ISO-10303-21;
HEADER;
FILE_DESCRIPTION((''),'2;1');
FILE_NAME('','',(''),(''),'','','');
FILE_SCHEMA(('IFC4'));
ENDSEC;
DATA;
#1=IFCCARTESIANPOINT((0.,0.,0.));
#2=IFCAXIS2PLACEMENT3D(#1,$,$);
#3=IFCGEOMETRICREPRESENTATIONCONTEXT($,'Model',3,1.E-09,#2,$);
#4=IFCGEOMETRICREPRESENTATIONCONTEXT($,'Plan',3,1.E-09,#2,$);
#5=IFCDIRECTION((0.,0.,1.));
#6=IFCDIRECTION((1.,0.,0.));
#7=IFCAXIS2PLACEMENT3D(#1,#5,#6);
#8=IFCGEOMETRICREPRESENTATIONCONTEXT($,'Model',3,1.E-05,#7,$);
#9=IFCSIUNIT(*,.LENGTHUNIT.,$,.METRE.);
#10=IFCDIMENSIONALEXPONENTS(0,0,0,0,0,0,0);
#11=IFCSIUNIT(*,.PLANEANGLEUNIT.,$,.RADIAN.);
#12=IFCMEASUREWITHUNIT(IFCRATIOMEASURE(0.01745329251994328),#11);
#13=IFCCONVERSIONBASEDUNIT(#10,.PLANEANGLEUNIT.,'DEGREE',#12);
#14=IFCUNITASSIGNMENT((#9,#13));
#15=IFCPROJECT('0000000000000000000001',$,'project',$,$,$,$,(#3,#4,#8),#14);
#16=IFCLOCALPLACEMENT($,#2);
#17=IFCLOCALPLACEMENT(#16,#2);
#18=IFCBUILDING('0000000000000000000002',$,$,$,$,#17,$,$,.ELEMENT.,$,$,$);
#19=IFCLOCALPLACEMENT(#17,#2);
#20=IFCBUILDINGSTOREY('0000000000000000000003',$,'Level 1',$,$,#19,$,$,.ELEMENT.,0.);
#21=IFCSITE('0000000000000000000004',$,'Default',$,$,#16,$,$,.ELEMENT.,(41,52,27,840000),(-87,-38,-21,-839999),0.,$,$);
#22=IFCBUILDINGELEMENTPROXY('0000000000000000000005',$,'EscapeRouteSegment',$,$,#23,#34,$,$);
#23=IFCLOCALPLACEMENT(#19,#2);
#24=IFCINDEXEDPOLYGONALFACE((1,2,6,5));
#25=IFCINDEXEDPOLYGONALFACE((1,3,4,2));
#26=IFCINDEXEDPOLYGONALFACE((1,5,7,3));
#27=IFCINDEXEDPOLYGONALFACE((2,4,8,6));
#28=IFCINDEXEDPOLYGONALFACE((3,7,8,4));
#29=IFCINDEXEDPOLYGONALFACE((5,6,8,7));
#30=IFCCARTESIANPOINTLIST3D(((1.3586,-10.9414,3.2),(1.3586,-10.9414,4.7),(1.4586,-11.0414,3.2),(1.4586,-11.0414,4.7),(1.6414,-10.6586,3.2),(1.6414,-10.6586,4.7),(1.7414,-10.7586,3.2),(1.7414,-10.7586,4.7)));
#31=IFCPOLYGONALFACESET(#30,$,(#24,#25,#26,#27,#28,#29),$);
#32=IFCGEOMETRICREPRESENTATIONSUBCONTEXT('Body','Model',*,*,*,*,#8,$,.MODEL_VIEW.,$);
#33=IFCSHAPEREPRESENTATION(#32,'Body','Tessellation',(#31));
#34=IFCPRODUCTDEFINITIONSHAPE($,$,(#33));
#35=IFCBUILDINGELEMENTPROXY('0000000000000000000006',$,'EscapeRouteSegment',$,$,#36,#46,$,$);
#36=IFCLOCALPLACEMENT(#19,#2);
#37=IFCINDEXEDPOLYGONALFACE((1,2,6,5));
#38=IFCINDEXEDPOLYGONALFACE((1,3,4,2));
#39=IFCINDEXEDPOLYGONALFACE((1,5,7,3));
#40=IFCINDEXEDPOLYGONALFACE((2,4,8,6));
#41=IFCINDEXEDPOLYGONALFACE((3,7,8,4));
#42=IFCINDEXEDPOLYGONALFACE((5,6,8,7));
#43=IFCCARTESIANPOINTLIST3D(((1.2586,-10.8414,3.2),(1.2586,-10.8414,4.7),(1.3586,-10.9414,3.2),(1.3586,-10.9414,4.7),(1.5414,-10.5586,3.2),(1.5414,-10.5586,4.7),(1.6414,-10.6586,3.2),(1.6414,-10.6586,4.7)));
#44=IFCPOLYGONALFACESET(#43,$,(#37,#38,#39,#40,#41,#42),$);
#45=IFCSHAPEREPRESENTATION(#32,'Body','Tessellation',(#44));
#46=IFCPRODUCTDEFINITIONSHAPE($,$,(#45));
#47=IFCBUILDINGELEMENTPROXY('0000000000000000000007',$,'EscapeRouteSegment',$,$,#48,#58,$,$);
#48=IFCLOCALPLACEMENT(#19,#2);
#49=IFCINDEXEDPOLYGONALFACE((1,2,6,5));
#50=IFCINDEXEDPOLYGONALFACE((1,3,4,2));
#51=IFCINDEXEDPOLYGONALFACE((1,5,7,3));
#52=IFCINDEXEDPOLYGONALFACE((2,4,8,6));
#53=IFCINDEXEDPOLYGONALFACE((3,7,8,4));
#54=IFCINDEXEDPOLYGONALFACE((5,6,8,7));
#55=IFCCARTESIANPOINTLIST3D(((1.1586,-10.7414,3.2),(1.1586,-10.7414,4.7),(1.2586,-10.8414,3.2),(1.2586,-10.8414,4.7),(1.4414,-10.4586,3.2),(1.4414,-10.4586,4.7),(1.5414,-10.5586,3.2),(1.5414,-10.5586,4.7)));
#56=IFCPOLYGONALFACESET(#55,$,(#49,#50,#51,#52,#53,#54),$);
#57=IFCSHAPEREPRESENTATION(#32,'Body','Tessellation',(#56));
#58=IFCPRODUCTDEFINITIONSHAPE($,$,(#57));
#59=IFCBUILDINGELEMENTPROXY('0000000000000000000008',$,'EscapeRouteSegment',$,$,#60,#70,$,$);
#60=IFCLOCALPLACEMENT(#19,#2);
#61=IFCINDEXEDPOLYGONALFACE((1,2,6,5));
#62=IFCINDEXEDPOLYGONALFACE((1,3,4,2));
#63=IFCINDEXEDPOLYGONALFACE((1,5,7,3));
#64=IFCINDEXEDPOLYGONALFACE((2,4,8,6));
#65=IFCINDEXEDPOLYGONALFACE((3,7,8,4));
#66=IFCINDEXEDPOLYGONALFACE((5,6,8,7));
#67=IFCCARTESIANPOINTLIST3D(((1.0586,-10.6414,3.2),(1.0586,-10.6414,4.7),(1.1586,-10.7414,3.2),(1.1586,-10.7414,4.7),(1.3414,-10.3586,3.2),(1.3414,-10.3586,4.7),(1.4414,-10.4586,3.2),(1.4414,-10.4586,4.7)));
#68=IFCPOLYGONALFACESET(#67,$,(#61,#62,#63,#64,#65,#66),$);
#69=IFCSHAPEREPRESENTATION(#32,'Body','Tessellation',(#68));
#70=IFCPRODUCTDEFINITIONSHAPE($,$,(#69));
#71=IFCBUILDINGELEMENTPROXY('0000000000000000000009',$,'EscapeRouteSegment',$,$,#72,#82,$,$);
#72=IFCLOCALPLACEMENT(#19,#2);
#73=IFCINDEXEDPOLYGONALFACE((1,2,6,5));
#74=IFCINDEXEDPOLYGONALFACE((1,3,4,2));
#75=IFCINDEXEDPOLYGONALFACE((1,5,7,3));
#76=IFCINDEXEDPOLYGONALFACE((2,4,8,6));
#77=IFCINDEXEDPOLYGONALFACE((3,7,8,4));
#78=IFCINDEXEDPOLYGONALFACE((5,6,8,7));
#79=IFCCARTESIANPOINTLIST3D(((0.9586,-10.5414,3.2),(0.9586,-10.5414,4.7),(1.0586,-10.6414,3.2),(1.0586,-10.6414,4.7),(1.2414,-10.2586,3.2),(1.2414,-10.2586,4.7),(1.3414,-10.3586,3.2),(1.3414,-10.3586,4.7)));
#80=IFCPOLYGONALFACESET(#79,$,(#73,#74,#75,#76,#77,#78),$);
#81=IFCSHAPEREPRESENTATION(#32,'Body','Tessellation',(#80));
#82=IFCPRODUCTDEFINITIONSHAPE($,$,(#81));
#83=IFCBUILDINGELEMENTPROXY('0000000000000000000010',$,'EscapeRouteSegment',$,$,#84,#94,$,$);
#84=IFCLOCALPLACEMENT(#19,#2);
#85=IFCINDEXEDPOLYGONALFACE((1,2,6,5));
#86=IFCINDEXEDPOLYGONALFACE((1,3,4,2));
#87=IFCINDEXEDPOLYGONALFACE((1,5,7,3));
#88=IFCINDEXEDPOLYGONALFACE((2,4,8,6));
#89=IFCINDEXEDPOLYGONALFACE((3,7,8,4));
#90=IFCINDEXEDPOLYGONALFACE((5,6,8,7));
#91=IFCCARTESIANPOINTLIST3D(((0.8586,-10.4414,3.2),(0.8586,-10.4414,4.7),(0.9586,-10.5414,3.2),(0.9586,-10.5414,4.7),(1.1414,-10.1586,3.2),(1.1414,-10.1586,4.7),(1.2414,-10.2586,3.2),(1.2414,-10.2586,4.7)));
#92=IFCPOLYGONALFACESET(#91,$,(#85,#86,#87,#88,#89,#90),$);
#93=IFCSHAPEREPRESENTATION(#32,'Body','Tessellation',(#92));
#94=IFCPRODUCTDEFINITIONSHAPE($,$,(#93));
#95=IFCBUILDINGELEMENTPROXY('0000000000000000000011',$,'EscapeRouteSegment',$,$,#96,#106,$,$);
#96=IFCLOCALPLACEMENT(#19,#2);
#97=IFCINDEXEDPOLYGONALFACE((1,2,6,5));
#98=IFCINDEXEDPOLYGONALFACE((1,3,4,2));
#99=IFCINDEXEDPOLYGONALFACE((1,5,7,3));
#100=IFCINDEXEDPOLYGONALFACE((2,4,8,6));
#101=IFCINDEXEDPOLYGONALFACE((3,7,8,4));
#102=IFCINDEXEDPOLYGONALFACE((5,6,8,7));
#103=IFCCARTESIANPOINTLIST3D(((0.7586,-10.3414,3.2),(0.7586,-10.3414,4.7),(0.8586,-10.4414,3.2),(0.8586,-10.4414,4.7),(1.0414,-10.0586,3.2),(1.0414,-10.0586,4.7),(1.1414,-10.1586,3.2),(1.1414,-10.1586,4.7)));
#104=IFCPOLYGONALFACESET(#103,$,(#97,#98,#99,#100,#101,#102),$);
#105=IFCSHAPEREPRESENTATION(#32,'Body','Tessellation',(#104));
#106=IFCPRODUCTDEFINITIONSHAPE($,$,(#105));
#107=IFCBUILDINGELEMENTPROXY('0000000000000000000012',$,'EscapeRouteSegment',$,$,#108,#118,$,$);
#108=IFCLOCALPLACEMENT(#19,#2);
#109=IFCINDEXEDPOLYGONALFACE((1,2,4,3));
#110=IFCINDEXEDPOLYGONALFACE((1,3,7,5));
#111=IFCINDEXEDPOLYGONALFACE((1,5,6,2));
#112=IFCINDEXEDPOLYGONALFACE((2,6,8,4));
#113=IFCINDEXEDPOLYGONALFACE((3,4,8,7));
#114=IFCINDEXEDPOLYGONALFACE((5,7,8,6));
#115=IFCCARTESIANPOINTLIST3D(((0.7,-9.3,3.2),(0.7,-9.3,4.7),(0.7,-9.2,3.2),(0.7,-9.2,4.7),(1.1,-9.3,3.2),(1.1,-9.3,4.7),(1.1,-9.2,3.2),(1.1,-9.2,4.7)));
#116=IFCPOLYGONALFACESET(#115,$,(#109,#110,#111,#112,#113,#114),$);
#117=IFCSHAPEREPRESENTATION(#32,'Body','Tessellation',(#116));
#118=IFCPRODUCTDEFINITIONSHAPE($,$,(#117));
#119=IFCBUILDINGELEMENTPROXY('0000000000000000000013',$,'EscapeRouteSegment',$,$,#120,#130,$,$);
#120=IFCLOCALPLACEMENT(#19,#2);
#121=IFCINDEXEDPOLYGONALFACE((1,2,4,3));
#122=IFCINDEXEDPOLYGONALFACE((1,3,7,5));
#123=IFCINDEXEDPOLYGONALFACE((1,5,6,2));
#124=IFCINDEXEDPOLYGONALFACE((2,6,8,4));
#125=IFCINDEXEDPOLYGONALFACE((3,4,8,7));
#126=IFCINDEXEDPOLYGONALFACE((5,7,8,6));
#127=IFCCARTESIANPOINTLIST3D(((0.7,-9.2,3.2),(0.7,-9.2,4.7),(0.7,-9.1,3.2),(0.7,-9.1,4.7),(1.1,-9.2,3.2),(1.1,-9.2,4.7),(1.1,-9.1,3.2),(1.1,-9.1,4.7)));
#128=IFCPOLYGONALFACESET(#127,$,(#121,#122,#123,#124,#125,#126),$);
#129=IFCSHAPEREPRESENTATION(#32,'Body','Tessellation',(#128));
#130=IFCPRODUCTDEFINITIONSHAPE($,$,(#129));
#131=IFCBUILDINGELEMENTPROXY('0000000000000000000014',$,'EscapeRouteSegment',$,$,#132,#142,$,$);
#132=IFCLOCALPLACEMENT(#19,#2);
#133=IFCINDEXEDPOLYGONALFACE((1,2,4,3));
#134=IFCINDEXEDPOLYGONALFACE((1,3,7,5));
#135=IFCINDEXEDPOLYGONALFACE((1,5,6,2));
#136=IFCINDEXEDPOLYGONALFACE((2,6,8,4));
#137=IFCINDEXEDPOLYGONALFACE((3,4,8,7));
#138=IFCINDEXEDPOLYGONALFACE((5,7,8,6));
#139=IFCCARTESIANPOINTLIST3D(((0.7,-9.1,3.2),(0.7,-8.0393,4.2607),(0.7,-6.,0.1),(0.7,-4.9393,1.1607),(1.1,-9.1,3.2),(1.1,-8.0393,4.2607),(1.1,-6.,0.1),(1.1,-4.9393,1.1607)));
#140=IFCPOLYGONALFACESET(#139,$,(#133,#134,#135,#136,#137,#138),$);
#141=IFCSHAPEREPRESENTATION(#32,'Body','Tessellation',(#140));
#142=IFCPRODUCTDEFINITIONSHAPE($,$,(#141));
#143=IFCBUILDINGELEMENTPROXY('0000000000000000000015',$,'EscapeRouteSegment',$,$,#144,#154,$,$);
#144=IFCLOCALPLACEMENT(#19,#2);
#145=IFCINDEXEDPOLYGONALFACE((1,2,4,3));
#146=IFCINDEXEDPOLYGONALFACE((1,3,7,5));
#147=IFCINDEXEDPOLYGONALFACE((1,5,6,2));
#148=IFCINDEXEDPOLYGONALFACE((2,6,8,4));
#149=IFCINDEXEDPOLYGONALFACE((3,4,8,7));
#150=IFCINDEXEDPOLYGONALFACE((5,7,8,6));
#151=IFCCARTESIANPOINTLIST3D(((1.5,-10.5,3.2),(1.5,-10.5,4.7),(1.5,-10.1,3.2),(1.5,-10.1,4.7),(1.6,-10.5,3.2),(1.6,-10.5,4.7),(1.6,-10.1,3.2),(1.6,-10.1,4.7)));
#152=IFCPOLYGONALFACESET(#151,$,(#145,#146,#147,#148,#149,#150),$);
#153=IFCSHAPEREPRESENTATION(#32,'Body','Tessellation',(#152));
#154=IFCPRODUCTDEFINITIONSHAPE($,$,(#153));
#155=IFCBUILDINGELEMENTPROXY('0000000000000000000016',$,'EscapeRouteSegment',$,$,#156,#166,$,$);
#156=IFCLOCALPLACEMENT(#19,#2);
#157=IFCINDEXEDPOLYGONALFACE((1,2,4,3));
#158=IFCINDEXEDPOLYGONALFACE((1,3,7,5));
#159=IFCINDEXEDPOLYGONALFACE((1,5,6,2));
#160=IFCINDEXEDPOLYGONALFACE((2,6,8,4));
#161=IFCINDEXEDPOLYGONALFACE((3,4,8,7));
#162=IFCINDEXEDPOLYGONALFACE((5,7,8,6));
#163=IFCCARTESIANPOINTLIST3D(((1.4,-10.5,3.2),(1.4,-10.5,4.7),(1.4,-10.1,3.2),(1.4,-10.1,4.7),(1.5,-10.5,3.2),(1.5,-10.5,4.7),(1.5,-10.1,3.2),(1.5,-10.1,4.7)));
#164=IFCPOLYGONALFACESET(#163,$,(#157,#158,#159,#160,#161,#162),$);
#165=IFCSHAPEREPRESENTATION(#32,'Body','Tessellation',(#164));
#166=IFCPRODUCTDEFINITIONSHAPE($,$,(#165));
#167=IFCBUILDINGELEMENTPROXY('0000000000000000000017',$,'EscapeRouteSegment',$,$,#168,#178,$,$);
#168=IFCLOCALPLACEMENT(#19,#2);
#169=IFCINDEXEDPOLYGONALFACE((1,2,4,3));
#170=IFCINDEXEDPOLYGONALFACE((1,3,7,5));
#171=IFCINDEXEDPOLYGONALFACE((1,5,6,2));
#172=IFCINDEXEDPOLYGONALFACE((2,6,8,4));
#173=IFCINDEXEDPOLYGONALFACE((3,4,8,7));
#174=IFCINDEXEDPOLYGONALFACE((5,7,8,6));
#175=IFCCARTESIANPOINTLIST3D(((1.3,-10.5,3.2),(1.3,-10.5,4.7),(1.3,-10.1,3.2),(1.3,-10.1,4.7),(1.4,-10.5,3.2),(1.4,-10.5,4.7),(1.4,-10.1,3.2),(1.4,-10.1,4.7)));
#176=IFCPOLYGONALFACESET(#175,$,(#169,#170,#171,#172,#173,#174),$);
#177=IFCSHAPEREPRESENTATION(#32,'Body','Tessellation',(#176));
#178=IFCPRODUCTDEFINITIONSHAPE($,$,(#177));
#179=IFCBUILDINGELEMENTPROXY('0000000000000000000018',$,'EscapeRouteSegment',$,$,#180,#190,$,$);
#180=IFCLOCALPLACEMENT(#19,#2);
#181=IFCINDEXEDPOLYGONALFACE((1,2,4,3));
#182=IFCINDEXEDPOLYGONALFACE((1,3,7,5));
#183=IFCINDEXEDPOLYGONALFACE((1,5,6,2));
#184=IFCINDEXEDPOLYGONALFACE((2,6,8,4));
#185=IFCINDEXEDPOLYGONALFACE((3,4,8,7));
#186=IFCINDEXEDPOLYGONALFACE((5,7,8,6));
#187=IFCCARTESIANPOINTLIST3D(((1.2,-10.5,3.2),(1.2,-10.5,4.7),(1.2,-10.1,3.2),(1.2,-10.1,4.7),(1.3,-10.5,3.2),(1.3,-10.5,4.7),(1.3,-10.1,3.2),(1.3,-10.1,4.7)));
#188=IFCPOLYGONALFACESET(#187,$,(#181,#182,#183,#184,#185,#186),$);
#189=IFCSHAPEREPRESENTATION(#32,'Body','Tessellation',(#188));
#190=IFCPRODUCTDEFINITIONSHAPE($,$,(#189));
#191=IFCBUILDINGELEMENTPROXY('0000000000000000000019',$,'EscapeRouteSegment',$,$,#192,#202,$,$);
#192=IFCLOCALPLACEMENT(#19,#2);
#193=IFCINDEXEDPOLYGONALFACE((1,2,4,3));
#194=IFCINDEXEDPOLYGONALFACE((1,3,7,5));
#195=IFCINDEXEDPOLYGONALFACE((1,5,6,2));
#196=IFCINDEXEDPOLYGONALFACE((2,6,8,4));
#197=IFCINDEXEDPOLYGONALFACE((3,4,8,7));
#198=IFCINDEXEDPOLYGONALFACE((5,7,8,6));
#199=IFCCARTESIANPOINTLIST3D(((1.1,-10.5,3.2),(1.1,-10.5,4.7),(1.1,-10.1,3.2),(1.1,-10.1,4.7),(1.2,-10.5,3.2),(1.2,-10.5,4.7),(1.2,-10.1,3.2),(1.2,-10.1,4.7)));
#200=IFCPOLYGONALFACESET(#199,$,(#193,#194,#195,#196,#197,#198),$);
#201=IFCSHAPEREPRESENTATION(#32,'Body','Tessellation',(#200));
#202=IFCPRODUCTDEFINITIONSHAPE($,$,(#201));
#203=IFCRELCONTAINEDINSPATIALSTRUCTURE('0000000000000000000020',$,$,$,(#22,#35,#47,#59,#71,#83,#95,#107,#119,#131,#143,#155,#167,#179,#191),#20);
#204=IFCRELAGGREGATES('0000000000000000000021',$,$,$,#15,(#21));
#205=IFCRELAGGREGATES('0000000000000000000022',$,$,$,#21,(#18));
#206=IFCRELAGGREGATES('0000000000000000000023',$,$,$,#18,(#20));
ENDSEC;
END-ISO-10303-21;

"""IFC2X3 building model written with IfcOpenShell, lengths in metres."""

from ifc_helpers import new_model, entity, si_unit, converted_unit, frame, origin, origin_with_axes, place, context, subcontext, project, spatial, polyline, outline, extrude, element, save


model = new_model("IFC2X3")

# Units and contexts
model_context_1 = context("Model", 3, precision=1e-09, world=origin())
plan_context = context("Plan", 3, precision=1e-09, world=origin())
model_context_2 = context("Model", 3, precision=1e-05, world=origin_with_axes())
body_context = subcontext(model_context_2, "Body", "Model", "MODEL_VIEW")
ifc_project = project(units=[si_unit("LENGTHUNIT", "METRE"), converted_unit("PLANEANGLEUNIT", "DEGREE", entity("IfcRatioMeasure", 0.01745329251994328), si_unit("PLANEANGLEUNIT", "RADIAN"), dimensions=[0, 0, 0, 0, 0, 0, 0])], contexts=[model_context_1, plan_context, model_context_2])

# Site, building, storey
site_placement = place(None, origin())
site = spatial("IfcSite", under=ifc_project, at=site_placement, Name="Default", CompositionType="ELEMENT", RefLatitude=(41, 52, 27, 840000), RefLongitude=(-87, -38, -21, -839999), RefElevation=0.0)
building_placement = place(site_placement, origin())
building = spatial("IfcBuilding", under=site, at=building_placement, CompositionType="ELEMENT")
storey_placement = place(building_placement, origin())
storey = spatial("IfcBuildingStorey", under=building, at=storey_placement, Name="Level 1", CompositionType="ELEMENT", Elevation=0.0)

# Building element proxies
proxy_1_placement = place(storey_placement, frame((1.6, -10.9, 3.2), z_axis=(0.0, 0.0, 1.0), x_axis=(-0.707109, 0.707105, 0.0)))
element("IfcBuildingElementProxy", 1, at=proxy_1_placement, inside=storey, Name="EscapeRouteSegment", context=body_context, shape_type="SweptSolid", body=[
    extrude(outline(polyline([(0.0, -0.2), (0.0, 0.2), (0.1414, 0.2), (0.1414, -0.2), (0.0, -0.2)])), origin_with_axes(), (0.0, 0.0, 1.0), 1.5),
])
proxy_2_placement = place(storey_placement, frame((1.5, -10.8, 3.2), z_axis=(0.0, 0.0, 1.0), x_axis=(-0.707105, 0.707108, 0.0)))
element("IfcBuildingElementProxy", 2, at=proxy_2_placement, inside=storey, Name="EscapeRouteSegment", context=body_context, shape_type="SweptSolid", body=[
    extrude(outline(polyline([(0.0, -0.2), (0.0, 0.2), (0.1414, 0.2), (0.1414, -0.2), (0.0, -0.2)])), origin_with_axes(), (0.0, 0.0, 1.0), 1.5),
])
proxy_3_placement = place(storey_placement, frame((1.4, -10.7, 3.2), z_axis=(0.0, 0.0, 1.0), x_axis=(-0.707109, 0.707105, 0.0)))
element("IfcBuildingElementProxy", 3, at=proxy_3_placement, inside=storey, Name="EscapeRouteSegment", context=body_context, shape_type="SweptSolid", body=[
    extrude(outline(polyline([(0.0, -0.2), (0.0, 0.2), (0.1414, 0.2), (0.1414, -0.2), (0.0, -0.2)])), origin_with_axes(), (0.0, 0.0, 1.0), 1.5),
])
proxy_4_placement = place(storey_placement, frame((1.3, -10.6, 3.2), z_axis=(0.0, 0.0, 1.0), x_axis=(-0.707105, 0.707108, 0.0)))
element("IfcBuildingElementProxy", 4, at=proxy_4_placement, inside=storey, Name="EscapeRouteSegment", context=body_context, shape_type="SweptSolid", body=[
    extrude(outline(polyline([(0.0, -0.2), (0.0, 0.2), (0.1414, 0.2), (0.1414, -0.2), (0.0, -0.2)])), origin_with_axes(), (0.0, 0.0, 1.0), 1.5),
])
proxy_5_placement = place(storey_placement, frame((1.2, -10.5, 3.2), z_axis=(0.0, 0.0, 1.0), x_axis=(-0.707105, 0.707108, 0.0)))
element("IfcBuildingElementProxy", 5, at=proxy_5_placement, inside=storey, Name="EscapeRouteSegment", context=body_context, shape_type="SweptSolid", body=[
    extrude(outline(polyline([(0.0, -0.2), (0.0, 0.2), (0.1414, 0.2), (0.1414, -0.2), (0.0, -0.2)])), origin_with_axes(), (0.0, 0.0, 1.0), 1.5),
])
proxy_6_placement = place(storey_placement, frame((1.1, -10.4, 3.2), z_axis=(0.0, 0.0, 1.0), x_axis=(-0.707109, 0.707105, 0.0)))
element("IfcBuildingElementProxy", 6, at=proxy_6_placement, inside=storey, Name="EscapeRouteSegment", context=body_context, shape_type="SweptSolid", body=[
    extrude(outline(polyline([(0.0, -0.2), (0.0, 0.2), (0.1414, 0.2), (0.1414, -0.2), (0.0, -0.2)])), origin_with_axes(), (0.0, 0.0, 1.0), 1.5),
])
proxy_7_placement = place(storey_placement, frame((1.0, -10.3, 3.2), z_axis=(0.0, 0.0, 1.0), x_axis=(-0.707105, 0.707108, 0.0)))
element("IfcBuildingElementProxy", 7, at=proxy_7_placement, inside=storey, Name="EscapeRouteSegment", context=body_context, shape_type="SweptSolid", body=[
    extrude(outline(polyline([(0.0, -0.2), (0.0, 0.2), (0.1414, 0.2), (0.1414, -0.2), (0.0, -0.2)])), origin_with_axes(), (0.0, 0.0, 1.0), 1.5),
])
proxy_8_placement = place(storey_placement, frame((0.9, -9.3, 3.2), z_axis=(0.0, 0.0, 1.0), x_axis=(0.0, 1.0, 0.0)))
element("IfcBuildingElementProxy", 8, at=proxy_8_placement, inside=storey, Name="EscapeRouteSegment", context=body_context, shape_type="SweptSolid", body=[
    extrude(outline(polyline([(0.0, -0.2), (0.0, 0.2), (0.1, 0.2), (0.1, -0.2), (0.0, -0.2)])), origin_with_axes(), (0.0, 0.0, 1.0), 1.5),
])
proxy_9_placement = place(storey_placement, frame((0.9, -9.2, 3.2), z_axis=(0.0, 0.0, 1.0), x_axis=(0.0, 1.0, 0.0)))
element("IfcBuildingElementProxy", 9, at=proxy_9_placement, inside=storey, Name="EscapeRouteSegment", context=body_context, shape_type="SweptSolid", body=[
    extrude(outline(polyline([(0.0, -0.2), (0.0, 0.2), (0.1, 0.2), (0.1, -0.2), (0.0, -0.2)])), origin_with_axes(), (0.0, 0.0, 1.0), 1.5),
])
proxy_10_placement = place(storey_placement, frame((0.9, -9.1, 3.2), z_axis=(0.0, 0.707107, 0.707107), x_axis=(0.0, 0.707107, -0.707107)))
element("IfcBuildingElementProxy", 10, at=proxy_10_placement, inside=storey, Name="EscapeRouteSegment", context=body_context, shape_type="SweptSolid", body=[
    extrude(outline(polyline([(0.0, -0.2), (0.0, 0.2), (4.3841, 0.2), (4.3841, -0.2), (0.0, -0.2)])), origin_with_axes(), (0.0, 0.0, 1.0), 1.5),
])
for number, where, z_axis, x_axis, name in (
    (11, (1.6, -10.3, 3.2), (0.0, 0.0, 1.0), (-1.0, 0.0, 0.0), "EscapeRouteSegment"),
    (12, (1.5, -10.3, 3.2), (0.0, 0.0, 1.0), (-1.0, 0.0, 0.0), "EscapeRouteSegment"),
    (13, (1.4, -10.3, 3.2), (0.0, 0.0, 1.0), (-1.0, 0.0, 0.0), "EscapeRouteSegment"),
):
    element("IfcBuildingElementProxy", number, at=place(storey_placement, frame(where, z_axis=z_axis, x_axis=x_axis)), inside=storey, Name=name, context=body_context, shape_type="SweptSolid", body=[
        extrude(outline(polyline([(0.0, -0.2), (0.0, 0.2), (0.1, 0.2), (0.1, -0.2), (0.0, -0.2)])), origin_with_axes(), (0.0, 0.0, 1.0), 1.5),
    ])
proxy_11_placement = place(storey_placement, frame((1.3, -10.3, 3.2), z_axis=(0.0, 0.0, 1.0), x_axis=(-1.0, 0.0, 0.0)))
element("IfcBuildingElementProxy", 14, at=proxy_11_placement, inside=storey, Name="EscapeRouteSegment", context=body_context, shape_type="SweptSolid", body=[
    extrude(outline(polyline([(0.0, -0.2), (0.0, 0.2), (0.1, 0.2), (0.1, -0.2), (0.0, -0.2)])), origin_with_axes(), (0.0, 0.0, 1.0), 1.5),
])
for number, where, z_axis, x_axis, name in (
    (15, (1.2, -10.3, 3.2), (0.0, 0.0, 1.0), (-1.0, 0.0, 0.0), "EscapeRouteSegment"),
):
    element("IfcBuildingElementProxy", number, at=place(storey_placement, frame(where, z_axis=z_axis, x_axis=x_axis)), inside=storey, Name=name, context=body_context, shape_type="SweptSolid", body=[
        extrude(outline(polyline([(0.0, -0.2), (0.0, 0.2), (0.1, 0.2), (0.1, -0.2), (0.0, -0.2)])), origin_with_axes(), (0.0, 0.0, 1.0), 1.5),
    ])

save(model, "model.ifc")
